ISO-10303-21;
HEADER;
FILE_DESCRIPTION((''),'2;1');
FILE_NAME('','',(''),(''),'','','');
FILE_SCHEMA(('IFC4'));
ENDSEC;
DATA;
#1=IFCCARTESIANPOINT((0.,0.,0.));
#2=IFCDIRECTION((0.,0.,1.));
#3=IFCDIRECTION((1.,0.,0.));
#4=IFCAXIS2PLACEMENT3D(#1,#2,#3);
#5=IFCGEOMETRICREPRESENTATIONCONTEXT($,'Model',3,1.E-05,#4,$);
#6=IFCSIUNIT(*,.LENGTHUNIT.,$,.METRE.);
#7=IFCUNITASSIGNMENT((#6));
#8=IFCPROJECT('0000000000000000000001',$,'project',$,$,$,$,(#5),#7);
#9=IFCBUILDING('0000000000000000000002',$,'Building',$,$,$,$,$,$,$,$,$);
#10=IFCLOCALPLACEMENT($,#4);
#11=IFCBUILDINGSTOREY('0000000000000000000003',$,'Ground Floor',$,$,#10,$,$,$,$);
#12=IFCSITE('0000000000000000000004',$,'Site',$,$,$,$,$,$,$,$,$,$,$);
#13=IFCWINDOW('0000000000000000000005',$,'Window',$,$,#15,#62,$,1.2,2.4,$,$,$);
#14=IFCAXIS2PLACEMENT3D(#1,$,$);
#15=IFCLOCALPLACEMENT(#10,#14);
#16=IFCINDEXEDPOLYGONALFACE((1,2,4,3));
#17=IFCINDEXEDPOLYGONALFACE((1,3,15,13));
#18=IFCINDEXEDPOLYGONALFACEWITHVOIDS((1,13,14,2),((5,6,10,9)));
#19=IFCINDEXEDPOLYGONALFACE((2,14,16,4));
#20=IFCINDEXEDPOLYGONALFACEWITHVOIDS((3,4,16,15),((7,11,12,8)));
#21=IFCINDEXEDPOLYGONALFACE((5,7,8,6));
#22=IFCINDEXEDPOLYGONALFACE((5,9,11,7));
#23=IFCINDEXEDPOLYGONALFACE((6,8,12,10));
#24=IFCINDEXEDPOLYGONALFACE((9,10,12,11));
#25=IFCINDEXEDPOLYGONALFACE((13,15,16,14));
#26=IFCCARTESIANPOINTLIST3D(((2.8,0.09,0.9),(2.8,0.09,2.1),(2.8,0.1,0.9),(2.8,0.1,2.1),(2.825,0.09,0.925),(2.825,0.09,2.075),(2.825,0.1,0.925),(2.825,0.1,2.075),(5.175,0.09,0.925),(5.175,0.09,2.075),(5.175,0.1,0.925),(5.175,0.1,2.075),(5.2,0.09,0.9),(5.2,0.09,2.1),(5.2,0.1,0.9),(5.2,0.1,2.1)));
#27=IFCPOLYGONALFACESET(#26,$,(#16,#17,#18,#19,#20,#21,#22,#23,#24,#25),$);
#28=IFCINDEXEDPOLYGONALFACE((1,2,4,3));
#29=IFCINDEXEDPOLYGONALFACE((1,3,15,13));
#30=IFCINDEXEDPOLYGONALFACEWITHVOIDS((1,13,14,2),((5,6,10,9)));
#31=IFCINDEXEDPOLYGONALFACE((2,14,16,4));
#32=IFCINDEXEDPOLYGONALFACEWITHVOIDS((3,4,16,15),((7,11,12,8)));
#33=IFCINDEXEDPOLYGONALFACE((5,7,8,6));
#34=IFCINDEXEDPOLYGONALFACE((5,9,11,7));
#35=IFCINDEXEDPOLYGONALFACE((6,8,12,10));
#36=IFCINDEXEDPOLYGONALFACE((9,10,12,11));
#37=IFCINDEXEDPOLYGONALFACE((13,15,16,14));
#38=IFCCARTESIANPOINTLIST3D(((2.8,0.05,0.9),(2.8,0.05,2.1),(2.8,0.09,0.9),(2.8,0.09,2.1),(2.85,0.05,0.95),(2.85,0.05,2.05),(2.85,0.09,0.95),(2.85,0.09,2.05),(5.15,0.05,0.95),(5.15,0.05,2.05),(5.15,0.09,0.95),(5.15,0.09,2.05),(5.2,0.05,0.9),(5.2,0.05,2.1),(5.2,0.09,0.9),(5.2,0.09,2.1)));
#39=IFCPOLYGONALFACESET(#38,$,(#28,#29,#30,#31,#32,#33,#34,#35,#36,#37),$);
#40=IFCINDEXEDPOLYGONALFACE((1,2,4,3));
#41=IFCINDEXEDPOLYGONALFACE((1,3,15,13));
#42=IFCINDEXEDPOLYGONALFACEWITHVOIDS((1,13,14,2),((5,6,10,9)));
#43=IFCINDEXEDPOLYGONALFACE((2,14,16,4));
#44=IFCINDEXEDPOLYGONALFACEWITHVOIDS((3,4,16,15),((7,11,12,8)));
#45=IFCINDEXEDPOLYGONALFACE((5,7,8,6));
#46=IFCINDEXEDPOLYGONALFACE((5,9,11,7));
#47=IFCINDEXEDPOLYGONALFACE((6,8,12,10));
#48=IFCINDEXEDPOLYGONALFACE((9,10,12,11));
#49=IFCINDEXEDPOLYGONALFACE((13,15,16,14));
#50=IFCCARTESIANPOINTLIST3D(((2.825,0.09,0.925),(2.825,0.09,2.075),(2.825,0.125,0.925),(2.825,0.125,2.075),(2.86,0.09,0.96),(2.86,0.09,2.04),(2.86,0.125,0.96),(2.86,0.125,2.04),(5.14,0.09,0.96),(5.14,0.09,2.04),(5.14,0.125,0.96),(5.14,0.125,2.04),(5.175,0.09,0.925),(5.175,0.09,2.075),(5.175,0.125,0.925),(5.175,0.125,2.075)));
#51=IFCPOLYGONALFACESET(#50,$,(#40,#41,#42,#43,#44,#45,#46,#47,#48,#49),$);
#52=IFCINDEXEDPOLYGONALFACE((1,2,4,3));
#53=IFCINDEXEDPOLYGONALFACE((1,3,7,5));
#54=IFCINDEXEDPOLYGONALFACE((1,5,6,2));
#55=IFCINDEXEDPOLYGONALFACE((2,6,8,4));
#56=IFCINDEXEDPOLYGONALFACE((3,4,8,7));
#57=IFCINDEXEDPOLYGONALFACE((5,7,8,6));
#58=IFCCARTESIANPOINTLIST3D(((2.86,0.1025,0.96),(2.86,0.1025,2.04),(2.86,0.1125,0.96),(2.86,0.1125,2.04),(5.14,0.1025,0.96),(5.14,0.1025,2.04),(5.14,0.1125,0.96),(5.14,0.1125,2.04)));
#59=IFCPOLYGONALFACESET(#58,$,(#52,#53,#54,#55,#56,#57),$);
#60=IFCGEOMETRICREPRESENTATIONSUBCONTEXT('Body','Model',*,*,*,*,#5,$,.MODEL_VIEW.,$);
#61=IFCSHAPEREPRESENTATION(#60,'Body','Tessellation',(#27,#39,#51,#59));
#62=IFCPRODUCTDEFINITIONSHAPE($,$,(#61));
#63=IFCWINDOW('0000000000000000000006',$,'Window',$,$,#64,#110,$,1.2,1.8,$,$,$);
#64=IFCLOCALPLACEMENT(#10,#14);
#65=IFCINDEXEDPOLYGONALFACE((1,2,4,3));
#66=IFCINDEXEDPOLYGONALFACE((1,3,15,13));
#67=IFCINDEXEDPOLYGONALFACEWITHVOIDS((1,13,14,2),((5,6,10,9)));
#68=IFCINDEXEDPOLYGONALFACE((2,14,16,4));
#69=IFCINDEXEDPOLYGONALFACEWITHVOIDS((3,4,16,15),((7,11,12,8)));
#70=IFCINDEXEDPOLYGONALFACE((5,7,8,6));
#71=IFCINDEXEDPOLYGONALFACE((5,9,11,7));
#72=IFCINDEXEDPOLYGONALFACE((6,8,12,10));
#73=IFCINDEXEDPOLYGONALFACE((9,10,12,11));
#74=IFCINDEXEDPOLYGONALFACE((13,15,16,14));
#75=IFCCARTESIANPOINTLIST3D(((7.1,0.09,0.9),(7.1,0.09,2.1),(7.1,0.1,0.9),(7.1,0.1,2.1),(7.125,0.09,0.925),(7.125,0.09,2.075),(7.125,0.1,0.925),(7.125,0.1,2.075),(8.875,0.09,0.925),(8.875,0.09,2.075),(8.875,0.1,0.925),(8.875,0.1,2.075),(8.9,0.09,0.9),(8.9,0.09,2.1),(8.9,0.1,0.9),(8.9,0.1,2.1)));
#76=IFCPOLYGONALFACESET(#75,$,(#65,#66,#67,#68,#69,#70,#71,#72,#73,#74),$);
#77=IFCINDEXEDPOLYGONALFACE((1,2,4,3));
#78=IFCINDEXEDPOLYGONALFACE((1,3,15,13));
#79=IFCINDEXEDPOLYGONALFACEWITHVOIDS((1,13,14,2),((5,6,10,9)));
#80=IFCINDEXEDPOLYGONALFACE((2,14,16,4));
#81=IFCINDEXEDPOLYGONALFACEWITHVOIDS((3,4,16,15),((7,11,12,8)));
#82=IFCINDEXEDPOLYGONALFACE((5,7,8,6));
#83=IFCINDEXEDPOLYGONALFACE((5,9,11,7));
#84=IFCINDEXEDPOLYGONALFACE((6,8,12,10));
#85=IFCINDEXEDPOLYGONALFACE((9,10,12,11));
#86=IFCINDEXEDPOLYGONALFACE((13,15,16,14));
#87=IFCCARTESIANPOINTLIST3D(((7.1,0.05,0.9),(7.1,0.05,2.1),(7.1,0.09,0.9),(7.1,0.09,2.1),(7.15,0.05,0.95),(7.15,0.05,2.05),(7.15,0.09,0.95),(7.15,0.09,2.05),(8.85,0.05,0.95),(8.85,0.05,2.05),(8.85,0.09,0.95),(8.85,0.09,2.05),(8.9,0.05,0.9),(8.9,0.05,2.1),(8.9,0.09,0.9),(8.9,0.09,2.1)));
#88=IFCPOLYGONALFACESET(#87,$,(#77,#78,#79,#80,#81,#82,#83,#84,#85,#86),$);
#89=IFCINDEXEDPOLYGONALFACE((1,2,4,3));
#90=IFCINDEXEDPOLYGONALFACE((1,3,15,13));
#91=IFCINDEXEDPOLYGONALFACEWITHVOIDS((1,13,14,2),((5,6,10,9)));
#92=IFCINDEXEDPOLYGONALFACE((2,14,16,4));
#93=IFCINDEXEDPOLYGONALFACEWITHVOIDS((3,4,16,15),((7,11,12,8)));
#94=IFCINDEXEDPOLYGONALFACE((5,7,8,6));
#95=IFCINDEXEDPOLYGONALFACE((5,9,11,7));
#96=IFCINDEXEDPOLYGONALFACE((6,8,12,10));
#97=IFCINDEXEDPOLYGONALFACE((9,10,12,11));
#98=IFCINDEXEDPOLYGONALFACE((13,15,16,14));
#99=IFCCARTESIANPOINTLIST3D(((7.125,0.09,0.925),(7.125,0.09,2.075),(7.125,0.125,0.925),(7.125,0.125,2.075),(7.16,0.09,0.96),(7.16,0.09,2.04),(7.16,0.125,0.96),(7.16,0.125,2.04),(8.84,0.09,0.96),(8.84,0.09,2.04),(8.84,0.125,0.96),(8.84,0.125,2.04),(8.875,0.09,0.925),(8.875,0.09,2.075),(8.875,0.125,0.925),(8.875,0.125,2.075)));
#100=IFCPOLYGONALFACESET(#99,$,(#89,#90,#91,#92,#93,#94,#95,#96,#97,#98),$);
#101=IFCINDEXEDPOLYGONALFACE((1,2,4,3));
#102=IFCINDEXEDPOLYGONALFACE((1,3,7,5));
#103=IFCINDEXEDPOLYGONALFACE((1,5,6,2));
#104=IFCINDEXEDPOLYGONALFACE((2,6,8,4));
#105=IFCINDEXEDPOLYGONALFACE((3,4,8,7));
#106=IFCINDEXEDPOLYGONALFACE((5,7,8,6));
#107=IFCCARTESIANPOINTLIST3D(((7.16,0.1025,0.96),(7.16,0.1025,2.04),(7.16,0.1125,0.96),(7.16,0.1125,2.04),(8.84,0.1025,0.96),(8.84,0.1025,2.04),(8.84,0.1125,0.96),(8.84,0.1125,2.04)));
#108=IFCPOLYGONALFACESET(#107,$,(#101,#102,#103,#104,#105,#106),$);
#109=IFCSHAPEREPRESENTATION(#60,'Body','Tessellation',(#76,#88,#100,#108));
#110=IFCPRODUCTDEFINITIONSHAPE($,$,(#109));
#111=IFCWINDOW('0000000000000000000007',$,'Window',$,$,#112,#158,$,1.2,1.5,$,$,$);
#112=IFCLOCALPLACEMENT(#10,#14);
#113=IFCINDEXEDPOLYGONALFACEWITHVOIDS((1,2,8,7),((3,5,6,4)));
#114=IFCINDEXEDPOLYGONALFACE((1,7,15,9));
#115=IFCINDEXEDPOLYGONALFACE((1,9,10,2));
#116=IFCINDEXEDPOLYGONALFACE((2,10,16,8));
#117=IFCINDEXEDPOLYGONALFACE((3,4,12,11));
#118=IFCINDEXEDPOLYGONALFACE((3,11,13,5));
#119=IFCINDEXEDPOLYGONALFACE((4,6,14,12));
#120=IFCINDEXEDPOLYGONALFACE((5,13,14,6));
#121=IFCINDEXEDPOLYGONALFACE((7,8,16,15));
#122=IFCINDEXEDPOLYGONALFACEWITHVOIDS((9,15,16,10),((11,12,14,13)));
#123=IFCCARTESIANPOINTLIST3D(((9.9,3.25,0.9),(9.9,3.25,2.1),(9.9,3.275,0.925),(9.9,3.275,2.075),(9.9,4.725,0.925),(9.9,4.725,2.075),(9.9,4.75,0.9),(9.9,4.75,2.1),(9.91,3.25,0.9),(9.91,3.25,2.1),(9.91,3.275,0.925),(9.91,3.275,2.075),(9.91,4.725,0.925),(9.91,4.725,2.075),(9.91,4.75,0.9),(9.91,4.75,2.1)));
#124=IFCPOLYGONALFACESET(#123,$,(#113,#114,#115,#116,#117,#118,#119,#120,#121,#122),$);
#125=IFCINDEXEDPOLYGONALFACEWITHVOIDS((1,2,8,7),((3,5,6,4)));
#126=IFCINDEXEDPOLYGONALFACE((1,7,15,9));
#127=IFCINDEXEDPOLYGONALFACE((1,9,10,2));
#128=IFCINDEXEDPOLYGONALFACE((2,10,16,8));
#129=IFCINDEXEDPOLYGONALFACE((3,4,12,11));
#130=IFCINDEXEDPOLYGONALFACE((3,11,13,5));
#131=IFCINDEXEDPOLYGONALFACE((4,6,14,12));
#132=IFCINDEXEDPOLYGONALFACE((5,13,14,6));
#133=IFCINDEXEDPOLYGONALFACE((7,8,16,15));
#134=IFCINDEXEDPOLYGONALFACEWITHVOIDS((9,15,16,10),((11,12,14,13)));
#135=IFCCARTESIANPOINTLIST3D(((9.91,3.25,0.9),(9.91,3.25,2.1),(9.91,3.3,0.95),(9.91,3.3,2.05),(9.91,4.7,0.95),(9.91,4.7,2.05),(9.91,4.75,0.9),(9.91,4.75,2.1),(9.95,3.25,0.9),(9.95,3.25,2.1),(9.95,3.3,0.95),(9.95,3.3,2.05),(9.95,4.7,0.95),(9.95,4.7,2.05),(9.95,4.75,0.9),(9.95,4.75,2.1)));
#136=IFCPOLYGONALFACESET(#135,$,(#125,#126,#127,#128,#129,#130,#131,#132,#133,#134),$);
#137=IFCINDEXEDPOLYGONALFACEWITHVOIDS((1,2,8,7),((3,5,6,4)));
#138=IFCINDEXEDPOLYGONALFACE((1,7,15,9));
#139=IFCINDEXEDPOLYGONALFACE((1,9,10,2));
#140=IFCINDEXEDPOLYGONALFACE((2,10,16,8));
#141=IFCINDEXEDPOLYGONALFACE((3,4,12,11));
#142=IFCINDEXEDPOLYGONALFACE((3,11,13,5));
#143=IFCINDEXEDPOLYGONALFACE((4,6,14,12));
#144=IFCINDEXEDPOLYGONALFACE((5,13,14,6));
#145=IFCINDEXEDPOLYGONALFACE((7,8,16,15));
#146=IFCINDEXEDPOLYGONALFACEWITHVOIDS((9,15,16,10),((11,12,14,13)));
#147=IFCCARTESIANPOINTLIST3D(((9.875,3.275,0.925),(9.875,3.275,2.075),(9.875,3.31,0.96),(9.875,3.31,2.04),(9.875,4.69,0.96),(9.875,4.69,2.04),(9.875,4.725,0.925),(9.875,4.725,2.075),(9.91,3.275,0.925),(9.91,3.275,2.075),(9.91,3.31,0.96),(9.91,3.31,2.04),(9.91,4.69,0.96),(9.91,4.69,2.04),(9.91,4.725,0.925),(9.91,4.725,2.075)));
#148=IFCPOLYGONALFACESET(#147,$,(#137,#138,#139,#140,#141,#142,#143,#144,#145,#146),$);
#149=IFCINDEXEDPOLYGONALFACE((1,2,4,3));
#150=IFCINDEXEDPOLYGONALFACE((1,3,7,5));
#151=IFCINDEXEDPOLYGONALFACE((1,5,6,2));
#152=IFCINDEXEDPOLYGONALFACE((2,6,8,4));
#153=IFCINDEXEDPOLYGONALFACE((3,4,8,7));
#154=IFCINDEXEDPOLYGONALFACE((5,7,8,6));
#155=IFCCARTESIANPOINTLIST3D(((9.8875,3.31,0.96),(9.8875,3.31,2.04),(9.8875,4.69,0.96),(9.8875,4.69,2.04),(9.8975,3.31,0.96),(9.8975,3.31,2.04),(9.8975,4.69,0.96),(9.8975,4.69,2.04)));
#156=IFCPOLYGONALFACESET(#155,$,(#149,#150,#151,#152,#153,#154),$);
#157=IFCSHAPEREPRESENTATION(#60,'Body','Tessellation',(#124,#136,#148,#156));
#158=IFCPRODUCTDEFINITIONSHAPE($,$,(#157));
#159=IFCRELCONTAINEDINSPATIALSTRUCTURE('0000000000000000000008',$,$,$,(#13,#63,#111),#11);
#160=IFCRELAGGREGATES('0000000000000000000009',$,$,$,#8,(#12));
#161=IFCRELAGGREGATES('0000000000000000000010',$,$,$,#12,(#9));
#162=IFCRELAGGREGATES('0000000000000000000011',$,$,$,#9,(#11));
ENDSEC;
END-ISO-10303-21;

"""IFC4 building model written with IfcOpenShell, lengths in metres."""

from ifc_helpers import new_model, si_unit, frame, origin_with_axes, place, context, subcontext, project, spatial, line, indexed_curve, outline, extrude, element, save


model = new_model("IFC4")

# Units and contexts
model_context = context("Model", 3, precision=1e-05, world=origin_with_axes())
body_context = subcontext(model_context, "Body", "Model", "MODEL_VIEW")
ifc_project = project(units=[si_unit("LENGTHUNIT", "METRE")], contexts=[model_context])

# Site, building, storey
site = spatial("IfcSite", under=ifc_project, Name="Site")
building = spatial("IfcBuilding", under=site, Name="Building")
storey_placement = place(None, origin_with_axes())
storey = spatial("IfcBuildingStorey", under=building, at=storey_placement, Name="Ground Floor")

# Windows
window_1_placement = place(storey_placement, frame((2.8, 0.0, 0.9), z_axis=(0.0, 0.0, 1.0), x_axis=(1.0, 0.0, 0.0)))
element("IfcWindow", 1, at=window_1_placement, inside=storey, Name="Window", OverallHeight=1.2, OverallWidth=2.4, context=body_context, shape_type="SweptSolid", body=[
    extrude(outline(indexed_curve([(0.0, 0.0), (2.4, 0.0), (2.4, 1.2), (0.0, 1.2)], segments=[line(1, 2, 3, 4, 1)]), holes=[indexed_curve([(0.025, 0.025), (2.375, 0.025), (2.375, 1.175), (0.025, 1.175)], segments=[line(1, 2, 3, 4, 1)])]), frame((0.0, 0.09, 0.0), z_axis=(0.0, -1.0, 0.0), x_axis=(1.0, 0.0, 0.0)), (0.0, 0.0, -1.0), 0.01),
    extrude(outline(indexed_curve([(0.0, 0.0), (2.4, 0.0), (2.4, 1.2), (0.0, 1.2)], segments=[line(1, 2, 3, 4, 1)]), holes=[indexed_curve([(0.05, 0.05), (2.35, 0.05), (2.35, 1.15), (0.05, 1.15)], segments=[line(1, 2, 3, 4, 1)])]), frame((0.0, 0.05, 0.0), z_axis=(0.0, -1.0, 0.0), x_axis=(1.0, 0.0, 0.0)), (0.0, 0.0, -1.0), 0.04),
    extrude(outline(indexed_curve([(0.0, 0.0), (2.35, 0.0), (2.35, 1.15), (0.0, 1.15)], segments=[line(1, 2, 3, 4, 1)]), holes=[indexed_curve([(0.035, 0.035), (2.315, 0.035), (2.315, 1.115), (0.035, 1.115)], segments=[line(1, 2, 3, 4, 1)])]), frame((0.025, 0.09, 0.025), z_axis=(0.0, -1.0, 0.0), x_axis=(1.0, 0.0, 0.0)), (0.0, 0.0, -1.0), 0.035),
    extrude(outline(indexed_curve([(0.035, 0.035), (2.315, 0.035), (2.315, 1.115), (0.035, 1.115)], segments=[line(1, 2, 3, 4, 1)])), frame((0.025, 0.1025, 0.025), z_axis=(0.0, -1.0, 0.0), x_axis=(1.0, 0.0, 0.0)), (0.0, 0.0, -1.0), 0.01),
])
window_2_placement = place(storey_placement, frame((7.1, 0.0, 0.9), z_axis=(0.0, 0.0, 1.0), x_axis=(1.0, 0.0, 0.0)))
element("IfcWindow", 2, at=window_2_placement, inside=storey, Name="Window", OverallHeight=1.2, OverallWidth=1.8, context=body_context, shape_type="SweptSolid", body=[
    extrude(outline(indexed_curve([(0.0, 0.0), (1.8, 0.0), (1.8, 1.2), (0.0, 1.2)], segments=[line(1, 2, 3, 4, 1)]), holes=[indexed_curve([(0.025, 0.025), (1.775, 0.025), (1.775, 1.175), (0.025, 1.175)], segments=[line(1, 2, 3, 4, 1)])]), frame((0.0, 0.09, 0.0), z_axis=(0.0, -1.0, 0.0), x_axis=(1.0, 0.0, 0.0)), (0.0, 0.0, -1.0), 0.01),
    extrude(outline(indexed_curve([(0.0, 0.0), (1.8, 0.0), (1.8, 1.2), (0.0, 1.2)], segments=[line(1, 2, 3, 4, 1)]), holes=[indexed_curve([(0.05, 0.05), (1.75, 0.05), (1.75, 1.15), (0.05, 1.15)], segments=[line(1, 2, 3, 4, 1)])]), frame((0.0, 0.05, 0.0), z_axis=(0.0, -1.0, 0.0), x_axis=(1.0, 0.0, 0.0)), (0.0, 0.0, -1.0), 0.04),
    extrude(outline(indexed_curve([(0.0, 0.0), (1.75, 0.0), (1.75, 1.15), (0.0, 1.15)], segments=[line(1, 2, 3, 4, 1)]), holes=[indexed_curve([(0.035, 0.035), (1.715, 0.035), (1.715, 1.115), (0.035, 1.115)], segments=[line(1, 2, 3, 4, 1)])]), frame((0.025, 0.09, 0.025), z_axis=(0.0, -1.0, 0.0), x_axis=(1.0, 0.0, 0.0)), (0.0, 0.0, -1.0), 0.035),
    extrude(outline(indexed_curve([(0.035, 0.035), (1.715, 0.035), (1.715, 1.115), (0.035, 1.115)], segments=[line(1, 2, 3, 4, 1)])), frame((0.025, 0.1025, 0.025), z_axis=(0.0, -1.0, 0.0), x_axis=(1.0, 0.0, 0.0)), (0.0, 0.0, -1.0), 0.01),
])
window_3_placement = place(storey_placement, frame((10.0, 3.25, 0.9), z_axis=(0.0, 0.0, 1.0), x_axis=(0.0, 1.0, 0.0)))
element("IfcWindow", 3, at=window_3_placement, inside=storey, Name="Window", OverallHeight=1.2, OverallWidth=1.5, context=body_context, shape_type="SweptSolid", body=[
    extrude(outline(indexed_curve([(0.0, 0.0), (1.5, 0.0), (1.5, 1.2), (0.0, 1.2)], segments=[line(1, 2, 3, 4, 1)]), holes=[indexed_curve([(0.025, 0.025), (1.475, 0.025), (1.475, 1.175), (0.025, 1.175)], segments=[line(1, 2, 3, 4, 1)])]), frame((0.0, 0.09, 0.0), z_axis=(0.0, -1.0, 0.0), x_axis=(1.0, 0.0, 0.0)), (0.0, 0.0, -1.0), 0.01),
    extrude(outline(indexed_curve([(0.0, 0.0), (1.5, 0.0), (1.5, 1.2), (0.0, 1.2)], segments=[line(1, 2, 3, 4, 1)]), holes=[indexed_curve([(0.05, 0.05), (1.45, 0.05), (1.45, 1.15), (0.05, 1.15)], segments=[line(1, 2, 3, 4, 1)])]), frame((0.0, 0.05, 0.0), z_axis=(0.0, -1.0, 0.0), x_axis=(1.0, 0.0, 0.0)), (0.0, 0.0, -1.0), 0.04),
    extrude(outline(indexed_curve([(0.0, 0.0), (1.45, 0.0), (1.45, 1.15), (0.0, 1.15)], segments=[line(1, 2, 3, 4, 1)]), holes=[indexed_curve([(0.035, 0.035), (1.415, 0.035), (1.415, 1.115), (0.035, 1.115)], segments=[line(1, 2, 3, 4, 1)])]), frame((0.025, 0.09, 0.025), z_axis=(0.0, -1.0, 0.0), x_axis=(1.0, 0.0, 0.0)), (0.0, 0.0, -1.0), 0.035),
    extrude(outline(indexed_curve([(0.035, 0.035), (1.415, 0.035), (1.415, 1.115), (0.035, 1.115)], segments=[line(1, 2, 3, 4, 1)])), frame((0.025, 0.1025, 0.025), z_axis=(0.0, -1.0, 0.0), x_axis=(1.0, 0.0, 0.0)), (0.0, 0.0, -1.0), 0.01),
])

save(model, "model.ifc")
